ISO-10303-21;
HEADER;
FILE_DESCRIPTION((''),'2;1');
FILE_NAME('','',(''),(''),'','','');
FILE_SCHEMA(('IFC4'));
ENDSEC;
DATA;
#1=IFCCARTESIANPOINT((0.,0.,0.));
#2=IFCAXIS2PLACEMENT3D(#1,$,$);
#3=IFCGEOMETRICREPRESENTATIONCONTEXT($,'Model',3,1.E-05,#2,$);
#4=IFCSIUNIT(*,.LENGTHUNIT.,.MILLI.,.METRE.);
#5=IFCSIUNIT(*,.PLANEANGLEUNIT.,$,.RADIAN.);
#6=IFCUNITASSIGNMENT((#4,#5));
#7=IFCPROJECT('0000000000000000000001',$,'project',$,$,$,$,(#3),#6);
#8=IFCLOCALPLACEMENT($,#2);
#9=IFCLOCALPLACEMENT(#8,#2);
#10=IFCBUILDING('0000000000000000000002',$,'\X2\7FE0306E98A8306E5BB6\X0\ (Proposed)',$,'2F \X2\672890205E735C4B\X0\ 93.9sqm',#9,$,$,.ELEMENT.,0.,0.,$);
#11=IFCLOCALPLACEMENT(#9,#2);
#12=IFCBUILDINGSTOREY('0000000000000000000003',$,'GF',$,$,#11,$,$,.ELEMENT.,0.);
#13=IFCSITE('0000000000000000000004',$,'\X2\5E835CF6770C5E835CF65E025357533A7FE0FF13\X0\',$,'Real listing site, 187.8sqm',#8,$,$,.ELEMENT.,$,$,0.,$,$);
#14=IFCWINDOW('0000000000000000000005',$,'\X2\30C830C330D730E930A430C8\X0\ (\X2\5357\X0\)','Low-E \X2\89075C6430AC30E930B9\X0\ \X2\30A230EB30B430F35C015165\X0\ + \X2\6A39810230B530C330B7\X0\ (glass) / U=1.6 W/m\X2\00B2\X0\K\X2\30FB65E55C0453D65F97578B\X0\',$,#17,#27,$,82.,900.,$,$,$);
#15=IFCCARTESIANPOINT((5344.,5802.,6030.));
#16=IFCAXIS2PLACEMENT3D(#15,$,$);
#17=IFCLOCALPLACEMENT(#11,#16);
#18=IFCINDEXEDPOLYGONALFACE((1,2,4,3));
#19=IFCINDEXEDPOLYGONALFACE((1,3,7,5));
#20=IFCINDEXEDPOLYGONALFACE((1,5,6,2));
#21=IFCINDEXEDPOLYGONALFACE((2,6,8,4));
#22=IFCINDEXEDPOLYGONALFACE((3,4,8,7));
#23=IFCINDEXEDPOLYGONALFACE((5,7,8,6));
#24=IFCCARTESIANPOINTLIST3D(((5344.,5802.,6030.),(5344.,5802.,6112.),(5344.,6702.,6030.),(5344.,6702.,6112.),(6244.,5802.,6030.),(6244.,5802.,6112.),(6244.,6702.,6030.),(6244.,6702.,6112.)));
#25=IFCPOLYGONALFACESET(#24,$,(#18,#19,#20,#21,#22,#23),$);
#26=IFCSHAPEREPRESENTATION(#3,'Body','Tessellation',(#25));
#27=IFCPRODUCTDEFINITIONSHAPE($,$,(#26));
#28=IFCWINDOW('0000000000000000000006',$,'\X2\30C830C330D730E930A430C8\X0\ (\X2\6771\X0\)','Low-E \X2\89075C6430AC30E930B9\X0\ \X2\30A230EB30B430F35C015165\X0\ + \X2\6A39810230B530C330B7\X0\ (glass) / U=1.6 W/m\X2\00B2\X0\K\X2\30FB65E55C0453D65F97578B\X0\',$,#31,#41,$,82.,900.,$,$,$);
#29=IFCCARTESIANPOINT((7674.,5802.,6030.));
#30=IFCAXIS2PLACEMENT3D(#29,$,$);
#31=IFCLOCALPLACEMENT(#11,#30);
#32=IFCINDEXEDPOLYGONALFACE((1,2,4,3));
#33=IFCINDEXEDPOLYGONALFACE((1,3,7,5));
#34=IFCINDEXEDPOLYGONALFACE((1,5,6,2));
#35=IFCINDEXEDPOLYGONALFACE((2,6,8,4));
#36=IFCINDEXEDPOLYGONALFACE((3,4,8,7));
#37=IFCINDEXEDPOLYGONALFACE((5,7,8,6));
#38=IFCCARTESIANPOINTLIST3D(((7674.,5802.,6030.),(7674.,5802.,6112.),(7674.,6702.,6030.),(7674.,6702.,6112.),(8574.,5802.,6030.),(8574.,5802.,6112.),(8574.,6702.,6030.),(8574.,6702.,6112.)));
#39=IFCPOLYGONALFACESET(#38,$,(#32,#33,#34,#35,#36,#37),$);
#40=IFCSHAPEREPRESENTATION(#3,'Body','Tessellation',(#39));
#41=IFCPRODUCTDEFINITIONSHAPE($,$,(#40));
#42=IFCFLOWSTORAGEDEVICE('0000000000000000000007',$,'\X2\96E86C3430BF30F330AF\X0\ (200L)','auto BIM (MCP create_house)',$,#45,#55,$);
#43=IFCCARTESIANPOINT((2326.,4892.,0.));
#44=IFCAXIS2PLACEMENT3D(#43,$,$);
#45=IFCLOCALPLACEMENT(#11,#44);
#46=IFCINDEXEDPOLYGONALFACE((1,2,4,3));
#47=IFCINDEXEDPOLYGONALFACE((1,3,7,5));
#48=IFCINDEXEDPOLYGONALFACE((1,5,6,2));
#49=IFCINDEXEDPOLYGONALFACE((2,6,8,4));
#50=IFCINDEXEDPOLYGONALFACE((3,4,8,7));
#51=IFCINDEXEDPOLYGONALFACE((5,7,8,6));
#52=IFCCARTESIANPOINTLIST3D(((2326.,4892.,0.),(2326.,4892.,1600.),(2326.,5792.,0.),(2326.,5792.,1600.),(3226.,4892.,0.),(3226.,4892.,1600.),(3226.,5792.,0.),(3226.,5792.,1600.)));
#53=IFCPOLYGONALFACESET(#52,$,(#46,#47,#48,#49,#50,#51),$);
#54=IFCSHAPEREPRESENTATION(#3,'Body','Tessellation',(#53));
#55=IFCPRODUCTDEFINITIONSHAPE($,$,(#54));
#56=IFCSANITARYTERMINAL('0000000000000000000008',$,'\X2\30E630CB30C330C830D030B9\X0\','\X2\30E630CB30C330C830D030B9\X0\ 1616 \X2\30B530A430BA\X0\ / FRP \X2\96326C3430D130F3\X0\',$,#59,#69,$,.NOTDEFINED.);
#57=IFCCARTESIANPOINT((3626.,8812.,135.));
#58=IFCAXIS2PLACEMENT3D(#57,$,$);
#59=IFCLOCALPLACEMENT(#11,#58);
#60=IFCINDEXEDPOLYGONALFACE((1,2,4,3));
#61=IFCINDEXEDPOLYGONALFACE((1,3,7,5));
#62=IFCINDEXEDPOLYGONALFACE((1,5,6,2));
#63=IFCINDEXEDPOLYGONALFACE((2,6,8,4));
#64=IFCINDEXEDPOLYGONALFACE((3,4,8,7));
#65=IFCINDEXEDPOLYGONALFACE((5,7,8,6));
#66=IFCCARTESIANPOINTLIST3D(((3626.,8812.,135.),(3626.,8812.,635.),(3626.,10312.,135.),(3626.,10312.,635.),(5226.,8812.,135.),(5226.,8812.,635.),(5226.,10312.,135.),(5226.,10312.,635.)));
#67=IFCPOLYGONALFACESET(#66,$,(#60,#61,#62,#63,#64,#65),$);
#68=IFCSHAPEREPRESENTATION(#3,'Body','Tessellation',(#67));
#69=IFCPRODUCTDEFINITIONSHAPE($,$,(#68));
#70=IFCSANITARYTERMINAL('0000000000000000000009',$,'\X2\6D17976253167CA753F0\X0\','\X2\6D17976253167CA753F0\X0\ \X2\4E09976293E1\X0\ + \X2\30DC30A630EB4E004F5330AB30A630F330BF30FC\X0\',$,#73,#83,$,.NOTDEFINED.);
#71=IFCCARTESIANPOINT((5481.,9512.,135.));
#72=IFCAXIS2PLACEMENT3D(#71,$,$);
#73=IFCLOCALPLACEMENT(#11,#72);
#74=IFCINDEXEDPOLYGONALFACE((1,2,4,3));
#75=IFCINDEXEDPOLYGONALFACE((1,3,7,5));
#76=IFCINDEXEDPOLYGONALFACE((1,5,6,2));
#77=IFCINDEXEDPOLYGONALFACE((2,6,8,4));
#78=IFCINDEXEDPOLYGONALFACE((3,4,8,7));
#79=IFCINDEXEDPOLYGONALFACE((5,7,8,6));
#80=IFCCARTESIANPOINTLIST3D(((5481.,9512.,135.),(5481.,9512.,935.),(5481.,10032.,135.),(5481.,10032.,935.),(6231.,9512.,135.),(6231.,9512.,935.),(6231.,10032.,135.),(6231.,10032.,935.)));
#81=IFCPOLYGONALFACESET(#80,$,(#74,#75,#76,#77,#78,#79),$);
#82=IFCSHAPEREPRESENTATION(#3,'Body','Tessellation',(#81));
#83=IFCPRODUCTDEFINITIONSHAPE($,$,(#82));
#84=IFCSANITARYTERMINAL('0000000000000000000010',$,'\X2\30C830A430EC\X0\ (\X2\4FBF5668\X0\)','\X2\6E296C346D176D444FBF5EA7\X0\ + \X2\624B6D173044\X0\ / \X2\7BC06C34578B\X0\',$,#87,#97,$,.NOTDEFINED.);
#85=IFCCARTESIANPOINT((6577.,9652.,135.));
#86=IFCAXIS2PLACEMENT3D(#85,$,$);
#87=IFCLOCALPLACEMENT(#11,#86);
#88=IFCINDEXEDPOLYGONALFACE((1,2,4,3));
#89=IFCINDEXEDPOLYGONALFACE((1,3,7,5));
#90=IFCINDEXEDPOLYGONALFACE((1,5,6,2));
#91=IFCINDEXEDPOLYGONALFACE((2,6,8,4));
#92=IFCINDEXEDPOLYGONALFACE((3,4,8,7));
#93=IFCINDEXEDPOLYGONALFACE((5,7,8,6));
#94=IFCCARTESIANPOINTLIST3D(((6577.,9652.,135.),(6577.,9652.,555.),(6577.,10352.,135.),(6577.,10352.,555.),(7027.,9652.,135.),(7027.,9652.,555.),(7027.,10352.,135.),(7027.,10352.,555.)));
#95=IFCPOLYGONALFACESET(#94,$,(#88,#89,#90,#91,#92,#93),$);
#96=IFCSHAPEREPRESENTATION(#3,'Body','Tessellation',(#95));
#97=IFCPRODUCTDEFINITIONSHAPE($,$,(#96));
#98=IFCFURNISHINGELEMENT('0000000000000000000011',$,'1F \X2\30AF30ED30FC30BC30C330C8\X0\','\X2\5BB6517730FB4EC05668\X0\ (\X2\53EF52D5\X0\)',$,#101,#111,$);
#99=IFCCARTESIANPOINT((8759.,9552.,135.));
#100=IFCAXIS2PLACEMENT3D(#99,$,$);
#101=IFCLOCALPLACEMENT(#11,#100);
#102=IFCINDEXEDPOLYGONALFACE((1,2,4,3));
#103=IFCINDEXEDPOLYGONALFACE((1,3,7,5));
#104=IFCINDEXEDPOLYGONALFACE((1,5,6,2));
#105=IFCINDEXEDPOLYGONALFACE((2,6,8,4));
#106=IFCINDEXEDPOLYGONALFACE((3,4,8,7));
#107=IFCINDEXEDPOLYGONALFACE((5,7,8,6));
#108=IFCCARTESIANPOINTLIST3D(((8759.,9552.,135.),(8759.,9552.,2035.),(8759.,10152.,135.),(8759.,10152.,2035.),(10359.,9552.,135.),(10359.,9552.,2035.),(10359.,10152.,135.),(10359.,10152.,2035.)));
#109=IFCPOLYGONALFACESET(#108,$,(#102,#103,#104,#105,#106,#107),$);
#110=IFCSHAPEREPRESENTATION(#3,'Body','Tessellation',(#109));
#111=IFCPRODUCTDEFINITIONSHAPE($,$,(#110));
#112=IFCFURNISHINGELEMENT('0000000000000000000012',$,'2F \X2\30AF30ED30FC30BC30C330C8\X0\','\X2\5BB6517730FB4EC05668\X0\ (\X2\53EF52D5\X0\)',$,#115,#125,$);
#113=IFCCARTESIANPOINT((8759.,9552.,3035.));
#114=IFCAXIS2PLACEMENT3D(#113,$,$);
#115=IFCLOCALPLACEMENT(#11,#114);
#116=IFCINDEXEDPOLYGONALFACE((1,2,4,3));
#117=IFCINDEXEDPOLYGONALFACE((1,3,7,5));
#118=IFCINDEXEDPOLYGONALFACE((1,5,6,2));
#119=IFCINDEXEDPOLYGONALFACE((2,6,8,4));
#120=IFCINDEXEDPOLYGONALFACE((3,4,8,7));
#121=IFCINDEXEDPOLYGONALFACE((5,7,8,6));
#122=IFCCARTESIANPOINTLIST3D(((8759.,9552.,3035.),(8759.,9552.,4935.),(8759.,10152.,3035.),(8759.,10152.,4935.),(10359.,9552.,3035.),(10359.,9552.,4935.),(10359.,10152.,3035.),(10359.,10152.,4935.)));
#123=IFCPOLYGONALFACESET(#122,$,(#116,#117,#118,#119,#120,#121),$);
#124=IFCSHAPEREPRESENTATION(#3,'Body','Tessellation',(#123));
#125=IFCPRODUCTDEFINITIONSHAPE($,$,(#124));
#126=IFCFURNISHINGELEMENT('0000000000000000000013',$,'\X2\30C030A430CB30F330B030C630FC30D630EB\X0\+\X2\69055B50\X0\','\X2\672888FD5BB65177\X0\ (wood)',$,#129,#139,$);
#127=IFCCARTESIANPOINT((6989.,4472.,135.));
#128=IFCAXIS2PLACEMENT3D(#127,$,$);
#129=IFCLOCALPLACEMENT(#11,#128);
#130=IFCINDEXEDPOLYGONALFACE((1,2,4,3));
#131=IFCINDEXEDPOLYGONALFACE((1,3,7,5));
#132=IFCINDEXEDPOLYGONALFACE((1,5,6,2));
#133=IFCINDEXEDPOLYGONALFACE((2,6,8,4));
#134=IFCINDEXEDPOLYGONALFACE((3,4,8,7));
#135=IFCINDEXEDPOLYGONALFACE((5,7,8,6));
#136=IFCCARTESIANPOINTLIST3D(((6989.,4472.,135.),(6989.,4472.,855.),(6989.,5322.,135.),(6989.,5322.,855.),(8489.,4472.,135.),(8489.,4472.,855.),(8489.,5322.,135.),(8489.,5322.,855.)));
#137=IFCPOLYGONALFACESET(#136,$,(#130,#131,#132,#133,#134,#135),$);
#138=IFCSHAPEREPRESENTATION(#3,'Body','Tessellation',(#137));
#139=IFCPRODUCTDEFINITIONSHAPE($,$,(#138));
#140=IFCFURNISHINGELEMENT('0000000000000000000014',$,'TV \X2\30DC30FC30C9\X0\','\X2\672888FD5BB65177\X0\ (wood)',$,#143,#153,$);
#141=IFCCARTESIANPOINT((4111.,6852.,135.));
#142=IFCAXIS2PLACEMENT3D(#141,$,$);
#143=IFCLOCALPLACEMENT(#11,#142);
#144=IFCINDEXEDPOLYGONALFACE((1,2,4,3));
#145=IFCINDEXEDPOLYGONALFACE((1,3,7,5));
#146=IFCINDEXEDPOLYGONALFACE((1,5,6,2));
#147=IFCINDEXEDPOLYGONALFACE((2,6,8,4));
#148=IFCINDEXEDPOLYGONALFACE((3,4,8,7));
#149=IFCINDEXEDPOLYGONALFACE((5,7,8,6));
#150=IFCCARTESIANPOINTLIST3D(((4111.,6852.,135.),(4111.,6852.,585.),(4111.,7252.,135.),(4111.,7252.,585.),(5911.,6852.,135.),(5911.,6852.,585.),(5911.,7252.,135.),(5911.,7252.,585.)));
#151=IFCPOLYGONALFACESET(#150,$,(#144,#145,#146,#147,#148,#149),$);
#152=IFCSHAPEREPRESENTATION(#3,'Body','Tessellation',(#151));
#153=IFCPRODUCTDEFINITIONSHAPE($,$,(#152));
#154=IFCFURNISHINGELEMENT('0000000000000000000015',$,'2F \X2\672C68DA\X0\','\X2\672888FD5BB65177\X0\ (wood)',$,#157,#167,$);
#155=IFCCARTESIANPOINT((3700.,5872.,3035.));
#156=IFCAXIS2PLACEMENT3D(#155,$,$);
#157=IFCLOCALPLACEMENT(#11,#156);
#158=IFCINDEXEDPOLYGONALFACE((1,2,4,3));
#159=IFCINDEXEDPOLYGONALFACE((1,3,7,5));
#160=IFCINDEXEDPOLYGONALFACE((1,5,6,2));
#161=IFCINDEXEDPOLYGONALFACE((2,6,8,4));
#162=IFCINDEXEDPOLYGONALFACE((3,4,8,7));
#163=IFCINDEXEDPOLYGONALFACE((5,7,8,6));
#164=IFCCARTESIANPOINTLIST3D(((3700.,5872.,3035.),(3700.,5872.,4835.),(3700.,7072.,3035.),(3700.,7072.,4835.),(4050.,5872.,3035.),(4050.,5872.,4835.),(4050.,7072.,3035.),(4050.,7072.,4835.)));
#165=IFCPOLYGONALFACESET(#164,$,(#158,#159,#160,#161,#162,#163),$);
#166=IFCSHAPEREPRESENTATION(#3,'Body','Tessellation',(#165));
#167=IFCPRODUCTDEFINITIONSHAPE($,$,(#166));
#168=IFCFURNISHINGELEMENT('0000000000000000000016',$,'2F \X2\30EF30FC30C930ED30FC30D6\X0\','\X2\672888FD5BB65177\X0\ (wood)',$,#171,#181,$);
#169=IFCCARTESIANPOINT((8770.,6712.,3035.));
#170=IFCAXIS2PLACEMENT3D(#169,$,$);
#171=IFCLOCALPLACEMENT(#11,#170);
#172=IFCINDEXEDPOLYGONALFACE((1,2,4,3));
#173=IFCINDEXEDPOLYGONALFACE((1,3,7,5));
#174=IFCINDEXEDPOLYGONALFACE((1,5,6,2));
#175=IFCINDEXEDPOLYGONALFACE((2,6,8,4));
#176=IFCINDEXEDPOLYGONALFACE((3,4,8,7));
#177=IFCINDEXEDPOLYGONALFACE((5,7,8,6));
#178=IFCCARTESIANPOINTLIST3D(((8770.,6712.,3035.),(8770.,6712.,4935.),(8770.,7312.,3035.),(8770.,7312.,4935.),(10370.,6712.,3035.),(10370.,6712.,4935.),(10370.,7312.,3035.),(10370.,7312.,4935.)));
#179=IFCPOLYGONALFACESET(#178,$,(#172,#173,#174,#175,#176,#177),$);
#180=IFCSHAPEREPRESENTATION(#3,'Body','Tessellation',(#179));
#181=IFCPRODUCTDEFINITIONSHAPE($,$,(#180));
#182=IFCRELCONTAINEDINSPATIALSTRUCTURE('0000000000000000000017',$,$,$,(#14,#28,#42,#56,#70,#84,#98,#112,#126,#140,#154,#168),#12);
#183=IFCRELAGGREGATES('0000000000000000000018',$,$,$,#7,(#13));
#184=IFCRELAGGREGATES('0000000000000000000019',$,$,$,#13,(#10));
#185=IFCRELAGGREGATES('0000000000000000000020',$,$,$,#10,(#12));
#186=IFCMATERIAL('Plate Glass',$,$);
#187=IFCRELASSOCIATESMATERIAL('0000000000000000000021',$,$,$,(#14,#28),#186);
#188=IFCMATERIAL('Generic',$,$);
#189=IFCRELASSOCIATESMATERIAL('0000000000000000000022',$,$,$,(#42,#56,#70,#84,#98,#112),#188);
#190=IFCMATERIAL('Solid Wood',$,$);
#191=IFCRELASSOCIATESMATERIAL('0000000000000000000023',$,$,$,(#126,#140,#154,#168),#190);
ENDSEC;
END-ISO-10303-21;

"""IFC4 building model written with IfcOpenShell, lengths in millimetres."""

from ifc_helpers import new_model, si_unit, frame, frame_2d, origin, place, context, project, spatial, rectangle, extrude, material, element, save


model = new_model("IFC4")

# Units and contexts
model_context = context("Model", 3, precision=1e-05, world=origin())
ifc_project = project(units=[si_unit("LENGTHUNIT", "METRE", prefix="MILLI"), si_unit("PLANEANGLEUNIT", "RADIAN")], contexts=[model_context])

# Site, building, storey
site_placement = place(None, origin())
site = spatial("IfcSite", under=ifc_project, at=site_placement, Name="広島県広島市南区翠３", ObjectType="Real listing site, 187.8sqm", CompositionType="ELEMENT", RefElevation=0.0)
building_placement = place(site_placement, origin())
building = spatial("IfcBuilding", under=site, at=building_placement, Name="翠の風の家 (Proposed)", ObjectType="2F 木造平屋 93.9sqm", CompositionType="ELEMENT", ElevationOfRefHeight=0.0, ElevationOfTerrain=0.0)
storey_placement = place(building_placement, origin())
storey = spatial("IfcBuildingStorey", under=building, at=storey_placement, Name="GF", CompositionType="ELEMENT", Elevation=0.0)

# Shared definitions
ifc_material_1 = material(Name="Solid Wood")
ifc_material_2 = material(Name="Plate Glass")

# Windows
window_1_placement = place(storey_placement, frame((5344.0, 5802.0, 6030.0)))
element("IfcWindow", 1, at=window_1_placement, inside=storey, material=ifc_material_2, Name="トップライト (南)", Description="Low-E 複層ガラス アルゴン封入 + 樹脂サッシ (glass) / U=1.6 W/m²K・日射取得型", OverallHeight=82.0, OverallWidth=900.0, context=model_context, shape_type="SweptSolid", body=[
    extrude(rectangle(XDim=900.0, YDim=900.0, at=frame_2d((450.0, 450.0))), frame((5344.0, 5802.0, 6030.0)), (0.0, 0.0, 1.0), 82.0),
])
window_2_placement = place(storey_placement, frame((7674.0, 5802.0, 6030.0)))
element("IfcWindow", 2, at=window_2_placement, inside=storey, material=ifc_material_2, Name="トップライト (東)", Description="Low-E 複層ガラス アルゴン封入 + 樹脂サッシ (glass) / U=1.6 W/m²K・日射取得型", OverallHeight=82.0, OverallWidth=900.0, context=model_context, shape_type="SweptSolid", body=[
    extrude(rectangle(XDim=900.0, YDim=900.0, at=frame_2d((450.0, 450.0))), frame((7674.0, 5802.0, 6030.0)), (0.0, 0.0, 1.0), 82.0),
])

# Flow storage device
ifc_material_3 = material(Name="Generic")
flow_storage_device_placement = place(storey_placement, frame((2326.0, 4892.0, 0.0)))
element("IfcFlowStorageDevice", 3, at=flow_storage_device_placement, inside=storey, material=ifc_material_3, Name="雨水タンク (200L)", Description="auto BIM (MCP create_house)", context=model_context, shape_type="SweptSolid", body=[
    extrude(rectangle(XDim=900.0, YDim=900.0, at=frame_2d((450.0, 450.0))), frame((2326.0, 4892.0, 0.0)), (0.0, 0.0, 1.0), 1600.0),
])

# Sanitary terminals
sanitary_terminal_1_placement = place(storey_placement, frame((3626.0, 8812.0, 135.0)))
element("IfcSanitaryTerminal", 4, at=sanitary_terminal_1_placement, inside=storey, material=ifc_material_3, Name="ユニットバス", Description="ユニットバス 1616 サイズ / FRP 防水パン", PredefinedType="NOTDEFINED", context=model_context, shape_type="SweptSolid", body=[
    extrude(rectangle(XDim=1600.0, YDim=1500.0, at=frame_2d((800.0, 750.0))), frame((3626.0, 8812.0, 135.0)), (0.0, 0.0, 1.0), 500.0),
])
sanitary_terminal_2_placement = place(storey_placement, frame((5481.0, 9512.0, 135.0)))
element("IfcSanitaryTerminal", 5, at=sanitary_terminal_2_placement, inside=storey, material=ifc_material_3, Name="洗面化粧台", Description="洗面化粧台 三面鏡 + ボウル一体カウンター", PredefinedType="NOTDEFINED", context=model_context, shape_type="SweptSolid", body=[
    extrude(rectangle(XDim=750.0, YDim=520.0, at=frame_2d((375.0, 260.0))), frame((5481.0, 9512.0, 135.0)), (0.0, 0.0, 1.0), 800.0),
])
sanitary_terminal_3_placement = place(storey_placement, frame((6577.0, 9652.0, 135.0)))
element("IfcSanitaryTerminal", 6, at=sanitary_terminal_3_placement, inside=storey, material=ifc_material_3, Name="トイレ (便器)", Description="温水洗浄便座 + 手洗い / 節水型", PredefinedType="NOTDEFINED", context=model_context, shape_type="SweptSolid", body=[
    extrude(rectangle(XDim=450.0, YDim=700.0, at=frame_2d((225.0, 350.0))), frame((6577.0, 9652.0, 135.0)), (0.0, 0.0, 1.0), 420.0),
])

# Furnishing elements
furnishing_1_placement = place(storey_placement, frame((8759.0, 9552.0, 135.0)))
element("IfcFurnishingElement", 7, at=furnishing_1_placement, inside=storey, material=ifc_material_3, Name="1F クローゼット", Description="家具・什器 (可動)", context=model_context, shape_type="SweptSolid", body=[
    extrude(rectangle(XDim=1600.0, YDim=600.0, at=frame_2d((800.0, 300.0))), frame((8759.0, 9552.0, 135.0)), (0.0, 0.0, 1.0), 1900.0),
])
furnishing_2_placement = place(storey_placement, frame((8759.0, 9552.0, 3035.0)))
element("IfcFurnishingElement", 8, at=furnishing_2_placement, inside=storey, material=ifc_material_3, Name="2F クローゼット", Description="家具・什器 (可動)", context=model_context, shape_type="SweptSolid", body=[
    extrude(rectangle(XDim=1600.0, YDim=600.0, at=frame_2d((800.0, 300.0))), frame((8759.0, 9552.0, 3035.0)), (0.0, 0.0, 1.0), 1900.0),
])
furnishing_3_placement = place(storey_placement, frame((6989.0, 4472.0, 135.0)))
element("IfcFurnishingElement", 9, at=furnishing_3_placement, inside=storey, material=ifc_material_1, Name="ダイニングテーブル+椅子", Description="木製家具 (wood)", context=model_context, shape_type="SweptSolid", body=[
    extrude(rectangle(XDim=1500.0, YDim=850.0, at=frame_2d((750.0, 425.0))), frame((6989.0, 4472.0, 135.0)), (0.0, 0.0, 1.0), 720.0),
])
furnishing_4_placement = place(storey_placement, frame((4111.0, 6852.0, 135.0)))
element("IfcFurnishingElement", 10, at=furnishing_4_placement, inside=storey, material=ifc_material_1, Name="TV ボード", Description="木製家具 (wood)", context=model_context, shape_type="SweptSolid", body=[
    extrude(rectangle(XDim=1800.0, YDim=400.0, at=frame_2d((900.0, 200.0))), frame((4111.0, 6852.0, 135.0)), (0.0, 0.0, 1.0), 450.0),
])
furnishing_5_placement = place(storey_placement, frame((3700.0, 5872.0, 3035.0)))
element("IfcFurnishingElement", 11, at=furnishing_5_placement, inside=storey, material=ifc_material_1, Name="2F 本棚", Description="木製家具 (wood)", context=model_context, shape_type="SweptSolid", body=[
    extrude(rectangle(XDim=350.0, YDim=1200.0, at=frame_2d((175.0, 600.0))), frame((3700.0, 5872.0, 3035.0)), (0.0, 0.0, 1.0), 1800.0),
])
furnishing_6_placement = place(storey_placement, frame((8770.0, 6712.0, 3035.0)))
element("IfcFurnishingElement", 12, at=furnishing_6_placement, inside=storey, material=ifc_material_1, Name="2F ワードローブ", Description="木製家具 (wood)", context=model_context, shape_type="SweptSolid", body=[
    extrude(rectangle(XDim=1600.0, YDim=600.0, at=frame_2d((800.0, 300.0))), frame((8770.0, 6712.0, 3035.0)), (0.0, 0.0, 1.0), 1900.0),
])

save(model, "model.ifc")
